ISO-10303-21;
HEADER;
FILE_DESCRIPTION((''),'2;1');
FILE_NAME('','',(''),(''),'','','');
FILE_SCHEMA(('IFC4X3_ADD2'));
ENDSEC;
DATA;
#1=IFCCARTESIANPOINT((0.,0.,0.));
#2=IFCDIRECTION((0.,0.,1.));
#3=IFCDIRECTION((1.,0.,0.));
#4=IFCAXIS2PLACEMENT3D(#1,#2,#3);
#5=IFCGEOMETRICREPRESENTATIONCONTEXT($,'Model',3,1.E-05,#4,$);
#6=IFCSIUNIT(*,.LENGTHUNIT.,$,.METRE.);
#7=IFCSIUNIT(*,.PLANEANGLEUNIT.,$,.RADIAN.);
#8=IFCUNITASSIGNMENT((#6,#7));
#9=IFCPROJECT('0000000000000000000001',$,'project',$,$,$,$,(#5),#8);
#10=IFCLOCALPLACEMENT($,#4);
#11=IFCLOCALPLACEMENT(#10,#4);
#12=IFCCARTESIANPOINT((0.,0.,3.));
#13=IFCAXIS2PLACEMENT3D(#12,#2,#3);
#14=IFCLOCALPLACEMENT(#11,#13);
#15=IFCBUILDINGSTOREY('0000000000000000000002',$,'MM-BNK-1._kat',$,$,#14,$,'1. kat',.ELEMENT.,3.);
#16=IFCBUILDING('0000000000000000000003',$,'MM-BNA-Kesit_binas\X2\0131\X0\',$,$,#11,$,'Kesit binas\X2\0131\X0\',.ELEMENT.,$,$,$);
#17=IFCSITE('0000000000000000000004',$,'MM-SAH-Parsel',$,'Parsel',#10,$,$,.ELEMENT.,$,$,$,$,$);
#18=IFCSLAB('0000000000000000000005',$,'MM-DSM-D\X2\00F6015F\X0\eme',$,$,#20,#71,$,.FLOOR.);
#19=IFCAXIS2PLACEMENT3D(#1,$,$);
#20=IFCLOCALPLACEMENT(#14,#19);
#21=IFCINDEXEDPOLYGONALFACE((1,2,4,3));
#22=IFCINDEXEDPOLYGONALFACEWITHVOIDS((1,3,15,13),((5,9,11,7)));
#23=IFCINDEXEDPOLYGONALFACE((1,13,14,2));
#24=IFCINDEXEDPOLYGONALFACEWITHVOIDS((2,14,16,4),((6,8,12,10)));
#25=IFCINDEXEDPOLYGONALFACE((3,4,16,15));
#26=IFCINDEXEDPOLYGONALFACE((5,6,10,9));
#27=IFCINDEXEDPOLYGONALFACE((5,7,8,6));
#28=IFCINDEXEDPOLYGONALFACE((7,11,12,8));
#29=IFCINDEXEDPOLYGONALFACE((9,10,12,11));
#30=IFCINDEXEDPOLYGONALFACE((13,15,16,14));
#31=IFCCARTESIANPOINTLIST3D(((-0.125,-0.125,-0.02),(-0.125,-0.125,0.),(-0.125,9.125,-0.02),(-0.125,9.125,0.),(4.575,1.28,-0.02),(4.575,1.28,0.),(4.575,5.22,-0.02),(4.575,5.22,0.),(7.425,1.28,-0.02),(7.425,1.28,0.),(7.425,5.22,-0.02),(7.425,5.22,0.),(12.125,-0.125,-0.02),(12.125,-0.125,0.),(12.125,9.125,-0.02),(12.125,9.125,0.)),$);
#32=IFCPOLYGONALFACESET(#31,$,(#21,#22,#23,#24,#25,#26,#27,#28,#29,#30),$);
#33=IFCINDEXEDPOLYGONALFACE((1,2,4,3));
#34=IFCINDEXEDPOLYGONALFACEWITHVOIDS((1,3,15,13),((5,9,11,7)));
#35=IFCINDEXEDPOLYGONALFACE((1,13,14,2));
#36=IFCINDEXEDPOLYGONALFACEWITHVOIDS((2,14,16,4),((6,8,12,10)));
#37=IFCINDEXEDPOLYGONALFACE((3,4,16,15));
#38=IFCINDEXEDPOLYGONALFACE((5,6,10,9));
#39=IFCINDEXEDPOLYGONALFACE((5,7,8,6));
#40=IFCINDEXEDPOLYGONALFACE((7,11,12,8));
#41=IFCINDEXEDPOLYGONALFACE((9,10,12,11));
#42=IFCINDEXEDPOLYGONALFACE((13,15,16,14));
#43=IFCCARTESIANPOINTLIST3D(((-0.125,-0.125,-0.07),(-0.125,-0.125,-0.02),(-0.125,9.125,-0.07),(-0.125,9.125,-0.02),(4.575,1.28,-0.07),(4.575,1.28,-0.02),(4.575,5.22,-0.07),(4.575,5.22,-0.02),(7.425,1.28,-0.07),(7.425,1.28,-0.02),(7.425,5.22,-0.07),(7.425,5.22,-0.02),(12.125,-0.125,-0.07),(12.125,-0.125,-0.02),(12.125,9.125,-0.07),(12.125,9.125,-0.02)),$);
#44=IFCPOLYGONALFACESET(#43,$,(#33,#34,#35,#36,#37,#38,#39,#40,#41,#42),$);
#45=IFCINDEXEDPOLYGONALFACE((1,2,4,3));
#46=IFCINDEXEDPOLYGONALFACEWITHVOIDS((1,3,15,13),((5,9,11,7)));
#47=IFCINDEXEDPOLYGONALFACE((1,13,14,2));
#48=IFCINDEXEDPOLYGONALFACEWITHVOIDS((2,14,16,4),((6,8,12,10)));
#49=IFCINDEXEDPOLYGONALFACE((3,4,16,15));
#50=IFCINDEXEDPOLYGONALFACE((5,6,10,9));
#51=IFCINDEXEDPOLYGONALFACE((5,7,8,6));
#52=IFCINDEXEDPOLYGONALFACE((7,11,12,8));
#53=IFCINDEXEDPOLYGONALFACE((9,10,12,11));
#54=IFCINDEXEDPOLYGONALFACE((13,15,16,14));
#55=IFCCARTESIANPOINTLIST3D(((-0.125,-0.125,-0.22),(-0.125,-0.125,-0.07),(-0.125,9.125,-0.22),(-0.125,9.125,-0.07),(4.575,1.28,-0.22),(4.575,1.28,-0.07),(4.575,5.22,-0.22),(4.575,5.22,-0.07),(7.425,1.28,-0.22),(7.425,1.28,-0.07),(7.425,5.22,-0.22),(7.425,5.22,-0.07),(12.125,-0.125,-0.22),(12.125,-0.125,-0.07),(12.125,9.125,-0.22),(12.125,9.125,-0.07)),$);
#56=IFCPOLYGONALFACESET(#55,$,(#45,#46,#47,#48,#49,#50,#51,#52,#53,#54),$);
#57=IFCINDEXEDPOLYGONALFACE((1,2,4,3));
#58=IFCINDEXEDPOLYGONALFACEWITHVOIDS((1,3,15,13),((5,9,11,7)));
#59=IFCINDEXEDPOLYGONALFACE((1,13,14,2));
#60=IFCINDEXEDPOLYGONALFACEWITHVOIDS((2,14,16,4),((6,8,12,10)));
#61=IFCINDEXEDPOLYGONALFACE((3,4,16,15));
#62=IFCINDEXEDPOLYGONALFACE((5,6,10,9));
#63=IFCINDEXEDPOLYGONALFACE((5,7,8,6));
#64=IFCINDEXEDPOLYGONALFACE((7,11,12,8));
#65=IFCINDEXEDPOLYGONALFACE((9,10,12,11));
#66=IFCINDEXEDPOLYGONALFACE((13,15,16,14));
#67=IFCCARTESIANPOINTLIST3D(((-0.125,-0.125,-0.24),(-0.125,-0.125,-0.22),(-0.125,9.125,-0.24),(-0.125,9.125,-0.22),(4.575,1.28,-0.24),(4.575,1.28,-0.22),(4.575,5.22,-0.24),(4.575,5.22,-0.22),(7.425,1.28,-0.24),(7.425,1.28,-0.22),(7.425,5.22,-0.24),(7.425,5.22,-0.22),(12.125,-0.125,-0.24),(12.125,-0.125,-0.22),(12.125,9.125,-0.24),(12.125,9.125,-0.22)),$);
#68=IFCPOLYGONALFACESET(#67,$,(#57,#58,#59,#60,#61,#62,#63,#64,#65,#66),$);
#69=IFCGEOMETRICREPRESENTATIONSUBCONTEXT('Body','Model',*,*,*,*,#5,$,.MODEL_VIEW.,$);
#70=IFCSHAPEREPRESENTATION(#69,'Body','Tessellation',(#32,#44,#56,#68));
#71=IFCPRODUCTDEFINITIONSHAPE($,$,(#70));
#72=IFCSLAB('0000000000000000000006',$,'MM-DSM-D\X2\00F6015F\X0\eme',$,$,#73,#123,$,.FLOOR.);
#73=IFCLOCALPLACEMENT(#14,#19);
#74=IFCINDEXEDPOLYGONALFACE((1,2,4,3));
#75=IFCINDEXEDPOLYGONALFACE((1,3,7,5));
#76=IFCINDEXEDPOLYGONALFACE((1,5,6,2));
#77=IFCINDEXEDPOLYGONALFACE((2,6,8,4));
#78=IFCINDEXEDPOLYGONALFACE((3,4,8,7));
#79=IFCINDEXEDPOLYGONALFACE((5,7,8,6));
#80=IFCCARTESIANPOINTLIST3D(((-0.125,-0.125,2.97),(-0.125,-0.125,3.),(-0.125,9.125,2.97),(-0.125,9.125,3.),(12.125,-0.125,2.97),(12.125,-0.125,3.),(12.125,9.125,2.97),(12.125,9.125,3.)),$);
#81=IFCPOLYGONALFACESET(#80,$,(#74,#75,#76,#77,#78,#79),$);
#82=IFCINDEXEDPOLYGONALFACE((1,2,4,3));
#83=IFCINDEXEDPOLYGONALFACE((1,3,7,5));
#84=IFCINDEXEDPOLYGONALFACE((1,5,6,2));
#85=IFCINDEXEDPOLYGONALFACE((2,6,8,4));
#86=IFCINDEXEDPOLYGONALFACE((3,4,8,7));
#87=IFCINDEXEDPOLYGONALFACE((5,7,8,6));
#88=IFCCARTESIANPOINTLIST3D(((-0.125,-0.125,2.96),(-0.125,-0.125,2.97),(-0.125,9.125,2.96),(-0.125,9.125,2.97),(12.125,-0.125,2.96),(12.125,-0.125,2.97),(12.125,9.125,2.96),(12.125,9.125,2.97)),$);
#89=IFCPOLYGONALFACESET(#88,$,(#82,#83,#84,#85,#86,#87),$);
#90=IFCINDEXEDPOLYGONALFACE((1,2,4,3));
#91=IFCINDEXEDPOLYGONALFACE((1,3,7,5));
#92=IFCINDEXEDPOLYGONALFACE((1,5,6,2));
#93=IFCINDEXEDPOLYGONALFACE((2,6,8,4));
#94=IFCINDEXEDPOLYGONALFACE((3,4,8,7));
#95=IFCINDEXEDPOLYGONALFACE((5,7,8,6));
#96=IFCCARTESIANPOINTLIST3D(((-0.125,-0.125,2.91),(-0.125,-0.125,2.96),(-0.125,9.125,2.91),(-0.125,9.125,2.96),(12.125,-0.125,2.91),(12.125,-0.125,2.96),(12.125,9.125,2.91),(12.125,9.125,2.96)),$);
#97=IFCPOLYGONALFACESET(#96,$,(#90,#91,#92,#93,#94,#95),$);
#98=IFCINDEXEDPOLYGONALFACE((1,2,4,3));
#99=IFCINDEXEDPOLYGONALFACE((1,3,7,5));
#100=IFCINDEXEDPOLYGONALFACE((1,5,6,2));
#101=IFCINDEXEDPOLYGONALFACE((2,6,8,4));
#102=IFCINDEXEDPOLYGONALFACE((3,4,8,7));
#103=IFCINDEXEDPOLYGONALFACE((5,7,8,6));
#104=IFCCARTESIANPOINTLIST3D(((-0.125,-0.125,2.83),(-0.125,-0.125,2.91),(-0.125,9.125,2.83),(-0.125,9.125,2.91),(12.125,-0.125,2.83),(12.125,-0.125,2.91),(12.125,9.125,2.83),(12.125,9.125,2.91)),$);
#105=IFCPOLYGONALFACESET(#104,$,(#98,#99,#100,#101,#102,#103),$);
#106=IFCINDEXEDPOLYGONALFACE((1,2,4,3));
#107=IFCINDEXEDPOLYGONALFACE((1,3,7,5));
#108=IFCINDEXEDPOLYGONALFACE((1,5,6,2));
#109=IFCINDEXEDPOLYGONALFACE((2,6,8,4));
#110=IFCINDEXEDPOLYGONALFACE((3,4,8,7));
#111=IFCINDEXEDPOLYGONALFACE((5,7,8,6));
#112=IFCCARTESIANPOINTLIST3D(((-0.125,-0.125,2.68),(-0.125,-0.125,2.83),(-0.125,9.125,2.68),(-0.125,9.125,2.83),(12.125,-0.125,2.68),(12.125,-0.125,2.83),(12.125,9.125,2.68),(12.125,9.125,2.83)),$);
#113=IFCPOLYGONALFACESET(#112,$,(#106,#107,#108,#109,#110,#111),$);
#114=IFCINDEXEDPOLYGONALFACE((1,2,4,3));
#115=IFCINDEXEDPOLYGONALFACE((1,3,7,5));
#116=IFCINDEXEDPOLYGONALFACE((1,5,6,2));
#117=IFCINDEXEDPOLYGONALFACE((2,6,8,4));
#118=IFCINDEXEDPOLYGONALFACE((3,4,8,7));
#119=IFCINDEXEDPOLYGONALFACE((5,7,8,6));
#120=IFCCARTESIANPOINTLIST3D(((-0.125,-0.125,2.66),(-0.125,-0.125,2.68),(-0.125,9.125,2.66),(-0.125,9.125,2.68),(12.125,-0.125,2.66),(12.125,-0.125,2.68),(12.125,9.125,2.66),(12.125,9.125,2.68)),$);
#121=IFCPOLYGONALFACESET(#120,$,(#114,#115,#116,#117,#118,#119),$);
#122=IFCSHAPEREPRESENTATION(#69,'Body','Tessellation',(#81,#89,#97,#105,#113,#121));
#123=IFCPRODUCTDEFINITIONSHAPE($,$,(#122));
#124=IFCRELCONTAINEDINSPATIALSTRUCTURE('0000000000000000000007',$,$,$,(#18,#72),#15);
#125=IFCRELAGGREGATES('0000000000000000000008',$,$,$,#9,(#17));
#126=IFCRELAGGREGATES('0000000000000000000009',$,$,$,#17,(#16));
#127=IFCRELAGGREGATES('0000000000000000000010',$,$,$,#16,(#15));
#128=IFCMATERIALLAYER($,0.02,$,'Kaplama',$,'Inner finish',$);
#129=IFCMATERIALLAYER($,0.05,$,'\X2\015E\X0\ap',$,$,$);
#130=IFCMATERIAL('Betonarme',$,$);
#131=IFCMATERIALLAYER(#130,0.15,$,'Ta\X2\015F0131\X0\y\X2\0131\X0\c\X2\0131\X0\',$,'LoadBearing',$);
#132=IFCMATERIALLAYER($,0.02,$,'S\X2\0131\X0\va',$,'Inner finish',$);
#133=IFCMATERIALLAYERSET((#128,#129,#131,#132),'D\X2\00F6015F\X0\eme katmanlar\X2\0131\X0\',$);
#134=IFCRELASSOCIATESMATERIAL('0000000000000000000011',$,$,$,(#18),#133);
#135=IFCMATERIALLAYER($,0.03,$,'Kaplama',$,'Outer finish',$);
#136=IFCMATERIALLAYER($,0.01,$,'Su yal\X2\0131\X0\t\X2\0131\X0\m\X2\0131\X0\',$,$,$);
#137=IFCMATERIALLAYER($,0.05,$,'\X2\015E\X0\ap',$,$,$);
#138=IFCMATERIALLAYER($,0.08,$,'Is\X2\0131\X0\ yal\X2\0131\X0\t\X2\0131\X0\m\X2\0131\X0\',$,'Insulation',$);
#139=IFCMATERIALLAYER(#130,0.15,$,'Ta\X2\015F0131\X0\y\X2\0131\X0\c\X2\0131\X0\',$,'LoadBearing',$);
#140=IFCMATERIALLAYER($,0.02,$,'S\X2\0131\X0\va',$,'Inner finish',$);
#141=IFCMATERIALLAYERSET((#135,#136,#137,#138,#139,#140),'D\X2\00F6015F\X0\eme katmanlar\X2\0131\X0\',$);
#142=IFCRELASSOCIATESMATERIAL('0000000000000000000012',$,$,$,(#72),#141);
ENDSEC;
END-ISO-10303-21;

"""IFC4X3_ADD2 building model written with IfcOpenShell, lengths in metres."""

from ifc_helpers import new_model, si_unit, frame, origin_with_axes, place, context, subcontext, project, spatial, polyline, outline, extrude, material, layer, layer_set, layer_usage, element, save


model = new_model("IFC4X3_ADD2")

# Units and contexts
model_context = context("Model", 3, precision=1e-05, world=origin_with_axes())
body_context = subcontext(model_context, "Body", "Model", "MODEL_VIEW")
ifc_project = project(units=[si_unit("LENGTHUNIT", "METRE"), si_unit("PLANEANGLEUNIT", "RADIAN")], contexts=[model_context])

# Site, building, storey
site_placement = place(None, origin_with_axes())
site = spatial("IfcSite", under=ifc_project, at=site_placement, Name="MM-SAH-Parsel", ObjectType="Parsel", CompositionType="ELEMENT")
building_placement = place(site_placement, origin_with_axes())
building = spatial("IfcBuilding", under=site, at=building_placement, Name="MM-BNA-Kesit_binası", LongName="Kesit binası", CompositionType="ELEMENT")
storey_placement = place(building_placement, frame((0.0, 0.0, 3.0), z_axis=(0.0, 0.0, 1.0), x_axis=(1.0, 0.0, 0.0)))
storey = spatial("IfcBuildingStorey", under=building, at=storey_placement, Name="MM-BNK-1._kat", LongName="1. kat", CompositionType="ELEMENT", Elevation=3.0)

# Shared definitions
ifc_material_1 = material(Name="Betonarme")

# Slab, opening
ifc_layer_1 = layer(None, 0.02, Name="Kaplama", Category="Inner finish")
ifc_layer_2 = layer(None, 0.05, Name="Şap")
ifc_layer_3 = layer(ifc_material_1, 0.15, Name="Taşıyıcı", Category="LoadBearing")
ifc_layer_4 = layer(None, 0.02, Name="Sıva", Category="Inner finish")
ifc_layer_set_1 = layer_set([ifc_layer_1, ifc_layer_2, ifc_layer_3, ifc_layer_4], Name="Döşeme katmanları")
ifc_layer_usage_1 = layer_usage(ifc_layer_set_1, "AXIS3", "NEGATIVE", 0.0)
slab_1_placement = place(storey_placement, origin_with_axes())
slab_1 = element("IfcSlab", 1, at=slab_1_placement, inside=storey, material=ifc_layer_usage_1, Name="MM-DSM-Döşeme", PredefinedType="FLOOR", context=body_context, shape_type="SweptSolid", body=[
    extrude(outline(polyline([(-0.125, -0.125), (12.125, -0.125), (12.125, 9.125), (-0.125, 9.125), (-0.125, -0.125)])), frame((0.0, 0.0, -0.02)), (0.0, 0.0, 1.0), 0.02),
    extrude(outline(polyline([(-0.125, -0.125), (12.125, -0.125), (12.125, 9.125), (-0.125, 9.125), (-0.125, -0.125)])), frame((0.0, 0.0, -0.07)), (0.0, 0.0, 1.0), 0.05),
    extrude(outline(polyline([(-0.125, -0.125), (12.125, -0.125), (12.125, 9.125), (-0.125, 9.125), (-0.125, -0.125)])), frame((0.0, 0.0, -0.22)), (0.0, 0.0, 1.0), 0.15),
    extrude(outline(polyline([(-0.125, -0.125), (12.125, -0.125), (12.125, 9.125), (-0.125, 9.125), (-0.125, -0.125)])), frame((0.0, 0.0, -0.24)), (0.0, 0.0, 1.0), 0.02),
])
opening_1_placement = place(storey_placement, origin_with_axes())
element("IfcOpeningElement", 2, at=opening_1_placement, cuts=slab_1, PredefinedType="OPENING", context=body_context, shape_type="SweptSolid", body=[
    extrude(outline(polyline([(4.575, 1.28), (4.575, 5.22), (7.425, 5.22), (7.425, 1.28), (4.575, 1.28)])), frame((0.0, 0.0, -0.24)), (0.0, 0.0, 1.0), 0.24),
])

# Slab
ifc_layer_5 = layer(None, 0.03, Name="Kaplama", Category="Outer finish")
ifc_layer_6 = layer(None, 0.01, Name="Su yalıtımı")
ifc_layer_7 = layer(None, 0.05, Name="Şap")
ifc_layer_8 = layer(None, 0.08, Name="Isı yalıtımı", Category="Insulation")
ifc_layer_9 = layer(ifc_material_1, 0.15, Name="Taşıyıcı", Category="LoadBearing")
ifc_layer_10 = layer(None, 0.02, Name="Sıva", Category="Inner finish")
ifc_layer_set_2 = layer_set([ifc_layer_5, ifc_layer_6, ifc_layer_7, ifc_layer_8, ifc_layer_9, ifc_layer_10], Name="Döşeme katmanları")
ifc_layer_usage_2 = layer_usage(ifc_layer_set_2, "AXIS3", "NEGATIVE", 3.0)
slab_2_placement = place(storey_placement, origin_with_axes())
element("IfcSlab", 3, at=slab_2_placement, inside=storey, material=ifc_layer_usage_2, Name="MM-DSM-Döşeme", PredefinedType="FLOOR", context=body_context, shape_type="SweptSolid", body=[
    extrude(outline(polyline([(-0.125, -0.125), (12.125, -0.125), (12.125, 9.125), (-0.125, 9.125), (-0.125, -0.125)])), frame((0.0, 0.0, 2.97)), (0.0, 0.0, 1.0), 0.03),
    extrude(outline(polyline([(-0.125, -0.125), (12.125, -0.125), (12.125, 9.125), (-0.125, 9.125), (-0.125, -0.125)])), frame((0.0, 0.0, 2.96)), (0.0, 0.0, 1.0), 0.01),
    extrude(outline(polyline([(-0.125, -0.125), (12.125, -0.125), (12.125, 9.125), (-0.125, 9.125), (-0.125, -0.125)])), frame((0.0, 0.0, 2.91)), (0.0, 0.0, 1.0), 0.05),
    extrude(outline(polyline([(-0.125, -0.125), (12.125, -0.125), (12.125, 9.125), (-0.125, 9.125), (-0.125, -0.125)])), frame((0.0, 0.0, 2.83)), (0.0, 0.0, 1.0), 0.08),
    extrude(outline(polyline([(-0.125, -0.125), (12.125, -0.125), (12.125, 9.125), (-0.125, 9.125), (-0.125, -0.125)])), frame((0.0, 0.0, 2.68)), (0.0, 0.0, 1.0), 0.15),
    extrude(outline(polyline([(-0.125, -0.125), (12.125, -0.125), (12.125, 9.125), (-0.125, 9.125), (-0.125, -0.125)])), frame((0.0, 0.0, 2.66)), (0.0, 0.0, 1.0), 0.02),
])

save(model, "model.ifc")
